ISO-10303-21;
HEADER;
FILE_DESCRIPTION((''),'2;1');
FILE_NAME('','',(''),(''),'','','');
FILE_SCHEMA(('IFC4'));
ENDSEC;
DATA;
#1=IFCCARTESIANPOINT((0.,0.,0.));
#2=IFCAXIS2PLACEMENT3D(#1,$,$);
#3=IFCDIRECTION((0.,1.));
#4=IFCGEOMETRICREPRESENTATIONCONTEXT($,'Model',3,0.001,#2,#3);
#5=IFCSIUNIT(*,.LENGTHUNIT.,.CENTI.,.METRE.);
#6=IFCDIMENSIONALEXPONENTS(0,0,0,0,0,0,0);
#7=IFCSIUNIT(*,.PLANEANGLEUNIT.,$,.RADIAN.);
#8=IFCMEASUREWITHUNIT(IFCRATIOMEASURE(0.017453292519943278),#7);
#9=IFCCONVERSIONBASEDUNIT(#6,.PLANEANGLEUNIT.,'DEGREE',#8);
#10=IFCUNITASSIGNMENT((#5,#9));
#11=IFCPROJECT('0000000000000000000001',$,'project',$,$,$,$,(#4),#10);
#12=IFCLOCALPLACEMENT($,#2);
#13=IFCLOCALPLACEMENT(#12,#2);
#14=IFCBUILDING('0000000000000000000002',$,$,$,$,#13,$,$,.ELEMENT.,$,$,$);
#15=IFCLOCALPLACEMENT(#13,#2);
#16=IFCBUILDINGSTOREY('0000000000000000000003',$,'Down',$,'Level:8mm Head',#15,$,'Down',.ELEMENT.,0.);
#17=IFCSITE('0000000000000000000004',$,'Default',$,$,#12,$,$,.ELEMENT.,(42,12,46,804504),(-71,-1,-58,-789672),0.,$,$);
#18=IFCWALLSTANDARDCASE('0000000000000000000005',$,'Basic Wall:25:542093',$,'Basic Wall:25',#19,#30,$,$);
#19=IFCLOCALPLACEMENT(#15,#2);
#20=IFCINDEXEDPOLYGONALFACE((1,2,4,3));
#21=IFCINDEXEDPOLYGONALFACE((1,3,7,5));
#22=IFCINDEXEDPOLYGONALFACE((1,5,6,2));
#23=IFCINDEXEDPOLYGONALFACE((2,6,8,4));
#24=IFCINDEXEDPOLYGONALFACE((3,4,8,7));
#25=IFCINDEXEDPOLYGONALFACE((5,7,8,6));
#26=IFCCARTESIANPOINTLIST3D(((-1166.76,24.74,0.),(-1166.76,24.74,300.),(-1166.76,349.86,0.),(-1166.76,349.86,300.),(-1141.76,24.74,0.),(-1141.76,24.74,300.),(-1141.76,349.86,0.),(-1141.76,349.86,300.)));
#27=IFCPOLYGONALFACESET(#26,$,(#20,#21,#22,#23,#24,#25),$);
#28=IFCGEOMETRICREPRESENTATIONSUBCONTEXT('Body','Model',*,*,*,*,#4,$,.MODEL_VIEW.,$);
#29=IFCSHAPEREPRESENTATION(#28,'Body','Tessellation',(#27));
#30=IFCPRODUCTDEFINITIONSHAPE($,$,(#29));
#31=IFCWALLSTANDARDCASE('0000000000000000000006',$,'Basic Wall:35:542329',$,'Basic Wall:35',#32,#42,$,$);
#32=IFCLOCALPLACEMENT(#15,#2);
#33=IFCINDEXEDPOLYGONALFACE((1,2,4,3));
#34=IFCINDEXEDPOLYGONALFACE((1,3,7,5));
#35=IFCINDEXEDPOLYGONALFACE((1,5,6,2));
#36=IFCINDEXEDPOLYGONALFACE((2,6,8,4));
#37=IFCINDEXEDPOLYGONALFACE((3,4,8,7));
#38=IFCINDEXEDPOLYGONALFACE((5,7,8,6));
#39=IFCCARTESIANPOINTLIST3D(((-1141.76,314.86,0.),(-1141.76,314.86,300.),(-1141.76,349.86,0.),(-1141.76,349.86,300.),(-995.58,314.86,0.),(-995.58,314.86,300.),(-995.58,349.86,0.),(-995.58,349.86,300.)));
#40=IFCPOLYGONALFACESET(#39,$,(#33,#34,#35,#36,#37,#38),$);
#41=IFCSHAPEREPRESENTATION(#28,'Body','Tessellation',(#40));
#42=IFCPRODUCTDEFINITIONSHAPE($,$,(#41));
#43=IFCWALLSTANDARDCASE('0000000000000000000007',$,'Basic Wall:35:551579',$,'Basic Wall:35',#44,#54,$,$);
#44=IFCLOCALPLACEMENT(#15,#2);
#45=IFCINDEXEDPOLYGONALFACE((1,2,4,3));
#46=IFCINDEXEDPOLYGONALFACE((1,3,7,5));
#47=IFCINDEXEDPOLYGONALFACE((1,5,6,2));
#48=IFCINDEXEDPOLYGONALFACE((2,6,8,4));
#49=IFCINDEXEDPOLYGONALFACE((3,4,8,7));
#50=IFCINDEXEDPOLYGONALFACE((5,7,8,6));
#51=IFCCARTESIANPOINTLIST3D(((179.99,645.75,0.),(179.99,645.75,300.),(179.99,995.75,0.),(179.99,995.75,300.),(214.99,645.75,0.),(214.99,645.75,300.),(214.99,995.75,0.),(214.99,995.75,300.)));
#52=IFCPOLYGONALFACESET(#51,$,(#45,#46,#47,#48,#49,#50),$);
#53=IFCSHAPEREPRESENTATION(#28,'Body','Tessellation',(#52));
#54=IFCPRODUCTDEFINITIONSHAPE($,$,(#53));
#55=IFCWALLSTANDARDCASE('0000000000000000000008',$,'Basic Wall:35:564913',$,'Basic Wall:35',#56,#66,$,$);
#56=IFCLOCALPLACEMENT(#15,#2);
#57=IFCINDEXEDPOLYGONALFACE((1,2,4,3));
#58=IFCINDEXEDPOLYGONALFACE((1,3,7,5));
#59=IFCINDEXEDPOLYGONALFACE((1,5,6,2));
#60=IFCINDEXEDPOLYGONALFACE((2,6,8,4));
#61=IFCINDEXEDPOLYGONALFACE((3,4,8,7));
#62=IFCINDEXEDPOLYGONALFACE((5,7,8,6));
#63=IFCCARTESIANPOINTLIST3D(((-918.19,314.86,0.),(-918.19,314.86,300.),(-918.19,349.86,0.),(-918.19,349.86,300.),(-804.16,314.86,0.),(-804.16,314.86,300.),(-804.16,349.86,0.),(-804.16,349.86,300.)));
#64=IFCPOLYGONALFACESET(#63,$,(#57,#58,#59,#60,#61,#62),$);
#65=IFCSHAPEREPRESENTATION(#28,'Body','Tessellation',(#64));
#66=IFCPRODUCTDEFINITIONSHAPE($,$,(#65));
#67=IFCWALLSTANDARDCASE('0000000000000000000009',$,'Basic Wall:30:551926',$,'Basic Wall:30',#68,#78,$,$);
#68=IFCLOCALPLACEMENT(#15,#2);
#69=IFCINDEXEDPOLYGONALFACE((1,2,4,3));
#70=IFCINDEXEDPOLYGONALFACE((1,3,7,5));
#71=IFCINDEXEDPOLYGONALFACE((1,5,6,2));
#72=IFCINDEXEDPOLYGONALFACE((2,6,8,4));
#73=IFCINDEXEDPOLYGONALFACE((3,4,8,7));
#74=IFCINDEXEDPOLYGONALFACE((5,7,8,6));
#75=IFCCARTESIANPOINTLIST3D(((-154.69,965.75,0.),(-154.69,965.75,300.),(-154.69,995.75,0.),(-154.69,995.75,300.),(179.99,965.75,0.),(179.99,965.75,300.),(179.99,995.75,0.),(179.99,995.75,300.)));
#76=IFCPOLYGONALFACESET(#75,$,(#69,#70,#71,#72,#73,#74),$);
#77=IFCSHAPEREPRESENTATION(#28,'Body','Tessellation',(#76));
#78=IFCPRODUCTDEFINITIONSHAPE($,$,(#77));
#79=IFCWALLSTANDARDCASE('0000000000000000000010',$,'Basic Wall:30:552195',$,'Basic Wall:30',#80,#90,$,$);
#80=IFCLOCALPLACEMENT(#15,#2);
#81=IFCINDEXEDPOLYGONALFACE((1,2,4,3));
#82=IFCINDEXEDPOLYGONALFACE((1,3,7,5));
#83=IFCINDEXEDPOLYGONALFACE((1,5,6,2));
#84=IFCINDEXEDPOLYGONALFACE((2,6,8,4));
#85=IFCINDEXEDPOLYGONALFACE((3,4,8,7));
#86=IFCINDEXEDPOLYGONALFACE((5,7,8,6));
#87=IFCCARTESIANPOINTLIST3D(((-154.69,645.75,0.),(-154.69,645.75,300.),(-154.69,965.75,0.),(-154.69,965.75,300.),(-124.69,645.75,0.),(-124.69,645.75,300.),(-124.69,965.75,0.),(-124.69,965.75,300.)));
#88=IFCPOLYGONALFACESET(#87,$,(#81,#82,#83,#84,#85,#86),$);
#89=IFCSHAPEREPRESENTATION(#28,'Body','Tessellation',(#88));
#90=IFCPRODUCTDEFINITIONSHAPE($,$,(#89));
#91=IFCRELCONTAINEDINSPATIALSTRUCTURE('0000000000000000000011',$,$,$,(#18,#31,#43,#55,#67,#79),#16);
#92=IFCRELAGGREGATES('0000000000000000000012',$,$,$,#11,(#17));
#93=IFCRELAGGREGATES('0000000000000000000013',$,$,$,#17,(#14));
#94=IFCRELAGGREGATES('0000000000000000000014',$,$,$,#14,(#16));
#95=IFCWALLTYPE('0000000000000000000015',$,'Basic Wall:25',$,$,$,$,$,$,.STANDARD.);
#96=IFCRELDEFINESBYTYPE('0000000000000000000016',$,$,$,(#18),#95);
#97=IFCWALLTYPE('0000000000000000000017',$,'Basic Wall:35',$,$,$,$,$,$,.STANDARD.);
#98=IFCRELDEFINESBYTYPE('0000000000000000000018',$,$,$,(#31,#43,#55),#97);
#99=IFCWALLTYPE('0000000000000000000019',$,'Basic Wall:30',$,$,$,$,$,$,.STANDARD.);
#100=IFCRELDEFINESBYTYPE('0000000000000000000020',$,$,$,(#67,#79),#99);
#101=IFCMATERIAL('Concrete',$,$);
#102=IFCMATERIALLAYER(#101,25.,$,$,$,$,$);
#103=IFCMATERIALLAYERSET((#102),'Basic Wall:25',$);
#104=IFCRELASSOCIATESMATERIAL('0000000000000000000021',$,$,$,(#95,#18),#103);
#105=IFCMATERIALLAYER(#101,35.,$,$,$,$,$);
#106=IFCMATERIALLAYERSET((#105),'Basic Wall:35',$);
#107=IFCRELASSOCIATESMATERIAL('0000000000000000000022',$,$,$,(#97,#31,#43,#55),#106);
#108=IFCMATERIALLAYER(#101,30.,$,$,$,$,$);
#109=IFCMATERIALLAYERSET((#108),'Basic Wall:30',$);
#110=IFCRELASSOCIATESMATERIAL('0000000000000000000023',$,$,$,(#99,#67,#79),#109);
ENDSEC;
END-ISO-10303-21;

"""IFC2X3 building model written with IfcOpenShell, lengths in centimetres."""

from ifc_helpers import new_model, entity, si_unit, converted_unit, direction, frame, frame_2d, origin, place, context, subcontext, project, spatial, rectangle, extrude, material, layer, layer_set, layer_usage, type_object, element, save


model = new_model("IFC2X3")

# Units and contexts
model_context = context("Model", 3, precision=0.001, world=origin(), true_north=direction((0.0, 1.0)))
body_context = subcontext(model_context, "Body", "Model", "MODEL_VIEW")
ifc_project = project(units=[si_unit("LENGTHUNIT", "METRE", prefix="CENTI"), converted_unit("PLANEANGLEUNIT", "DEGREE", entity("IfcRatioMeasure", 0.017453292519943278), si_unit("PLANEANGLEUNIT", "RADIAN"), dimensions=[0, 0, 0, 0, 0, 0, 0])], contexts=[model_context])

# Site, building, storey
site_placement = place(None, origin())
site = spatial("IfcSite", under=ifc_project, at=site_placement, Name="Default", CompositionType="ELEMENT", RefLatitude=(42, 12, 46, 804504), RefLongitude=(-71, -1, -58, -789672), RefElevation=0.0)
building_placement = place(site_placement, origin())
building = spatial("IfcBuilding", under=site, at=building_placement, CompositionType="ELEMENT")
storey_placement = place(building_placement, origin())
storey = spatial("IfcBuildingStorey", under=building, at=storey_placement, Name="Down", ObjectType="Level:8mm Head", LongName="Down", CompositionType="ELEMENT", Elevation=0.0)

# Shared definitions
ifc_material = material(Name="Concrete")

# Walls
ifc_layer_1 = layer(ifc_material, 25.0)
ifc_layer_set_1 = layer_set([ifc_layer_1], Name="Basic Wall:25")
ifc_layer_usage_1 = layer_usage(ifc_layer_set_1, "AXIS2", "NEGATIVE", 12.5)
wall_type_1 = type_object("IfcWallType", Name="Basic Wall:25", PredefinedType="STANDARD", material=ifc_layer_set_1)
wall_1_placement = place(storey_placement, frame((-1154.26, 24.74, 0.0), z_axis=(0.0, 0.0, 1.0), x_axis=(0.0, 1.0, 0.0)))
element("IfcWallStandardCase", 1, at=wall_1_placement, inside=storey, type_object=wall_type_1, material=ifc_layer_usage_1, Name="Basic Wall:25:542093", ObjectType="Basic Wall:25", context=body_context, shape_type="SweptSolid", body=[
    extrude(rectangle(XDim=325.12, YDim=25.0, at=frame_2d((162.56, 0.0), x_axis=(-1.0, 0.0))), origin(), (0.0, 0.0, 1.0), 300.0),
])
ifc_layer_2 = layer(ifc_material, 35.0)
ifc_layer_set_2 = layer_set([ifc_layer_2], Name="Basic Wall:35")
ifc_layer_usage_2 = layer_usage(ifc_layer_set_2, "AXIS2", "NEGATIVE", 17.5)
wall_type_2 = type_object("IfcWallType", Name="Basic Wall:35", PredefinedType="STANDARD", material=ifc_layer_set_2)
wall_2_placement = place(storey_placement, frame((-1141.76, 332.36, 0.0)))
element("IfcWallStandardCase", 2, at=wall_2_placement, inside=storey, type_object=wall_type_2, material=ifc_layer_usage_2, Name="Basic Wall:35:542329", ObjectType="Basic Wall:35", context=body_context, shape_type="SweptSolid", body=[
    extrude(rectangle(XDim=146.18, YDim=35.0, at=frame_2d((73.09, 0.0), x_axis=(-1.0, 0.0))), origin(), (0.0, 0.0, 1.0), 300.0),
])
ifc_layer_usage_3 = layer_usage(ifc_layer_set_2, "AXIS2", "POSITIVE", -17.5)
wall_3_placement = place(storey_placement, frame((197.49, 645.75, 0.0), z_axis=(0.0, 0.0, 1.0), x_axis=(0.0, 1.0, 0.0)))
element("IfcWallStandardCase", 3, at=wall_3_placement, inside=storey, type_object=wall_type_2, material=ifc_layer_usage_3, Name="Basic Wall:35:551579", ObjectType="Basic Wall:35", context=body_context, shape_type="SweptSolid", body=[
    extrude(rectangle(XDim=350.0, YDim=35.0, at=frame_2d((175.0, 0.0), x_axis=(-1.0, 0.0))), origin(), (0.0, 0.0, 1.0), 300.0),
])
ifc_layer_usage_4 = layer_usage(ifc_layer_set_2, "AXIS2", "POSITIVE", -17.5)
wall_4_placement = place(storey_placement, frame((-804.16, 332.36, 0.0), z_axis=(0.0, 0.0, 1.0), x_axis=(-1.0, 0.0, 0.0)))
element("IfcWallStandardCase", 4, at=wall_4_placement, inside=storey, type_object=wall_type_2, material=ifc_layer_usage_4, Name="Basic Wall:35:564913", ObjectType="Basic Wall:35", context=body_context, shape_type="SweptSolid", body=[
    extrude(rectangle(XDim=114.02, YDim=35.0, at=frame_2d((57.01, 0.0), x_axis=(-1.0, 0.0))), origin(), (0.0, 0.0, 1.0), 300.0),
])
ifc_layer_3 = layer(ifc_material, 30.0)
ifc_layer_set_3 = layer_set([ifc_layer_3], Name="Basic Wall:30")
ifc_layer_usage_5 = layer_usage(ifc_layer_set_3, "AXIS2", "POSITIVE", -15.0)
wall_type_3 = type_object("IfcWallType", Name="Basic Wall:30", PredefinedType="STANDARD", material=ifc_layer_set_3)
wall_5_placement = place(storey_placement, frame((179.99, 980.75, 0.0), z_axis=(0.0, 0.0, 1.0), x_axis=(-1.0, 0.0, 0.0)))
element("IfcWallStandardCase", 5, at=wall_5_placement, inside=storey, type_object=wall_type_3, material=ifc_layer_usage_5, Name="Basic Wall:30:551926", ObjectType="Basic Wall:30", context=body_context, shape_type="SweptSolid", body=[
    extrude(rectangle(XDim=334.68, YDim=30.0, at=frame_2d((167.34, 0.0), x_axis=(-1.0, 0.0))), origin(), (0.0, 0.0, 1.0), 300.0),
])
ifc_layer_usage_6 = layer_usage(ifc_layer_set_3, "AXIS2", "POSITIVE", -15.0)
wall_6_placement = place(storey_placement, frame((-139.69, 965.75, 0.0), z_axis=(0.0, 0.0, 1.0), x_axis=(0.0, -1.0, 0.0)))
element("IfcWallStandardCase", 6, at=wall_6_placement, inside=storey, type_object=wall_type_3, material=ifc_layer_usage_6, Name="Basic Wall:30:552195", ObjectType="Basic Wall:30", context=body_context, shape_type="SweptSolid", body=[
    extrude(rectangle(XDim=320.0, YDim=30.0, at=frame_2d((160.0, 0.0), x_axis=(-1.0, 0.0))), origin(), (0.0, 0.0, 1.0), 300.0),
])

save(model, "model.ifc")
